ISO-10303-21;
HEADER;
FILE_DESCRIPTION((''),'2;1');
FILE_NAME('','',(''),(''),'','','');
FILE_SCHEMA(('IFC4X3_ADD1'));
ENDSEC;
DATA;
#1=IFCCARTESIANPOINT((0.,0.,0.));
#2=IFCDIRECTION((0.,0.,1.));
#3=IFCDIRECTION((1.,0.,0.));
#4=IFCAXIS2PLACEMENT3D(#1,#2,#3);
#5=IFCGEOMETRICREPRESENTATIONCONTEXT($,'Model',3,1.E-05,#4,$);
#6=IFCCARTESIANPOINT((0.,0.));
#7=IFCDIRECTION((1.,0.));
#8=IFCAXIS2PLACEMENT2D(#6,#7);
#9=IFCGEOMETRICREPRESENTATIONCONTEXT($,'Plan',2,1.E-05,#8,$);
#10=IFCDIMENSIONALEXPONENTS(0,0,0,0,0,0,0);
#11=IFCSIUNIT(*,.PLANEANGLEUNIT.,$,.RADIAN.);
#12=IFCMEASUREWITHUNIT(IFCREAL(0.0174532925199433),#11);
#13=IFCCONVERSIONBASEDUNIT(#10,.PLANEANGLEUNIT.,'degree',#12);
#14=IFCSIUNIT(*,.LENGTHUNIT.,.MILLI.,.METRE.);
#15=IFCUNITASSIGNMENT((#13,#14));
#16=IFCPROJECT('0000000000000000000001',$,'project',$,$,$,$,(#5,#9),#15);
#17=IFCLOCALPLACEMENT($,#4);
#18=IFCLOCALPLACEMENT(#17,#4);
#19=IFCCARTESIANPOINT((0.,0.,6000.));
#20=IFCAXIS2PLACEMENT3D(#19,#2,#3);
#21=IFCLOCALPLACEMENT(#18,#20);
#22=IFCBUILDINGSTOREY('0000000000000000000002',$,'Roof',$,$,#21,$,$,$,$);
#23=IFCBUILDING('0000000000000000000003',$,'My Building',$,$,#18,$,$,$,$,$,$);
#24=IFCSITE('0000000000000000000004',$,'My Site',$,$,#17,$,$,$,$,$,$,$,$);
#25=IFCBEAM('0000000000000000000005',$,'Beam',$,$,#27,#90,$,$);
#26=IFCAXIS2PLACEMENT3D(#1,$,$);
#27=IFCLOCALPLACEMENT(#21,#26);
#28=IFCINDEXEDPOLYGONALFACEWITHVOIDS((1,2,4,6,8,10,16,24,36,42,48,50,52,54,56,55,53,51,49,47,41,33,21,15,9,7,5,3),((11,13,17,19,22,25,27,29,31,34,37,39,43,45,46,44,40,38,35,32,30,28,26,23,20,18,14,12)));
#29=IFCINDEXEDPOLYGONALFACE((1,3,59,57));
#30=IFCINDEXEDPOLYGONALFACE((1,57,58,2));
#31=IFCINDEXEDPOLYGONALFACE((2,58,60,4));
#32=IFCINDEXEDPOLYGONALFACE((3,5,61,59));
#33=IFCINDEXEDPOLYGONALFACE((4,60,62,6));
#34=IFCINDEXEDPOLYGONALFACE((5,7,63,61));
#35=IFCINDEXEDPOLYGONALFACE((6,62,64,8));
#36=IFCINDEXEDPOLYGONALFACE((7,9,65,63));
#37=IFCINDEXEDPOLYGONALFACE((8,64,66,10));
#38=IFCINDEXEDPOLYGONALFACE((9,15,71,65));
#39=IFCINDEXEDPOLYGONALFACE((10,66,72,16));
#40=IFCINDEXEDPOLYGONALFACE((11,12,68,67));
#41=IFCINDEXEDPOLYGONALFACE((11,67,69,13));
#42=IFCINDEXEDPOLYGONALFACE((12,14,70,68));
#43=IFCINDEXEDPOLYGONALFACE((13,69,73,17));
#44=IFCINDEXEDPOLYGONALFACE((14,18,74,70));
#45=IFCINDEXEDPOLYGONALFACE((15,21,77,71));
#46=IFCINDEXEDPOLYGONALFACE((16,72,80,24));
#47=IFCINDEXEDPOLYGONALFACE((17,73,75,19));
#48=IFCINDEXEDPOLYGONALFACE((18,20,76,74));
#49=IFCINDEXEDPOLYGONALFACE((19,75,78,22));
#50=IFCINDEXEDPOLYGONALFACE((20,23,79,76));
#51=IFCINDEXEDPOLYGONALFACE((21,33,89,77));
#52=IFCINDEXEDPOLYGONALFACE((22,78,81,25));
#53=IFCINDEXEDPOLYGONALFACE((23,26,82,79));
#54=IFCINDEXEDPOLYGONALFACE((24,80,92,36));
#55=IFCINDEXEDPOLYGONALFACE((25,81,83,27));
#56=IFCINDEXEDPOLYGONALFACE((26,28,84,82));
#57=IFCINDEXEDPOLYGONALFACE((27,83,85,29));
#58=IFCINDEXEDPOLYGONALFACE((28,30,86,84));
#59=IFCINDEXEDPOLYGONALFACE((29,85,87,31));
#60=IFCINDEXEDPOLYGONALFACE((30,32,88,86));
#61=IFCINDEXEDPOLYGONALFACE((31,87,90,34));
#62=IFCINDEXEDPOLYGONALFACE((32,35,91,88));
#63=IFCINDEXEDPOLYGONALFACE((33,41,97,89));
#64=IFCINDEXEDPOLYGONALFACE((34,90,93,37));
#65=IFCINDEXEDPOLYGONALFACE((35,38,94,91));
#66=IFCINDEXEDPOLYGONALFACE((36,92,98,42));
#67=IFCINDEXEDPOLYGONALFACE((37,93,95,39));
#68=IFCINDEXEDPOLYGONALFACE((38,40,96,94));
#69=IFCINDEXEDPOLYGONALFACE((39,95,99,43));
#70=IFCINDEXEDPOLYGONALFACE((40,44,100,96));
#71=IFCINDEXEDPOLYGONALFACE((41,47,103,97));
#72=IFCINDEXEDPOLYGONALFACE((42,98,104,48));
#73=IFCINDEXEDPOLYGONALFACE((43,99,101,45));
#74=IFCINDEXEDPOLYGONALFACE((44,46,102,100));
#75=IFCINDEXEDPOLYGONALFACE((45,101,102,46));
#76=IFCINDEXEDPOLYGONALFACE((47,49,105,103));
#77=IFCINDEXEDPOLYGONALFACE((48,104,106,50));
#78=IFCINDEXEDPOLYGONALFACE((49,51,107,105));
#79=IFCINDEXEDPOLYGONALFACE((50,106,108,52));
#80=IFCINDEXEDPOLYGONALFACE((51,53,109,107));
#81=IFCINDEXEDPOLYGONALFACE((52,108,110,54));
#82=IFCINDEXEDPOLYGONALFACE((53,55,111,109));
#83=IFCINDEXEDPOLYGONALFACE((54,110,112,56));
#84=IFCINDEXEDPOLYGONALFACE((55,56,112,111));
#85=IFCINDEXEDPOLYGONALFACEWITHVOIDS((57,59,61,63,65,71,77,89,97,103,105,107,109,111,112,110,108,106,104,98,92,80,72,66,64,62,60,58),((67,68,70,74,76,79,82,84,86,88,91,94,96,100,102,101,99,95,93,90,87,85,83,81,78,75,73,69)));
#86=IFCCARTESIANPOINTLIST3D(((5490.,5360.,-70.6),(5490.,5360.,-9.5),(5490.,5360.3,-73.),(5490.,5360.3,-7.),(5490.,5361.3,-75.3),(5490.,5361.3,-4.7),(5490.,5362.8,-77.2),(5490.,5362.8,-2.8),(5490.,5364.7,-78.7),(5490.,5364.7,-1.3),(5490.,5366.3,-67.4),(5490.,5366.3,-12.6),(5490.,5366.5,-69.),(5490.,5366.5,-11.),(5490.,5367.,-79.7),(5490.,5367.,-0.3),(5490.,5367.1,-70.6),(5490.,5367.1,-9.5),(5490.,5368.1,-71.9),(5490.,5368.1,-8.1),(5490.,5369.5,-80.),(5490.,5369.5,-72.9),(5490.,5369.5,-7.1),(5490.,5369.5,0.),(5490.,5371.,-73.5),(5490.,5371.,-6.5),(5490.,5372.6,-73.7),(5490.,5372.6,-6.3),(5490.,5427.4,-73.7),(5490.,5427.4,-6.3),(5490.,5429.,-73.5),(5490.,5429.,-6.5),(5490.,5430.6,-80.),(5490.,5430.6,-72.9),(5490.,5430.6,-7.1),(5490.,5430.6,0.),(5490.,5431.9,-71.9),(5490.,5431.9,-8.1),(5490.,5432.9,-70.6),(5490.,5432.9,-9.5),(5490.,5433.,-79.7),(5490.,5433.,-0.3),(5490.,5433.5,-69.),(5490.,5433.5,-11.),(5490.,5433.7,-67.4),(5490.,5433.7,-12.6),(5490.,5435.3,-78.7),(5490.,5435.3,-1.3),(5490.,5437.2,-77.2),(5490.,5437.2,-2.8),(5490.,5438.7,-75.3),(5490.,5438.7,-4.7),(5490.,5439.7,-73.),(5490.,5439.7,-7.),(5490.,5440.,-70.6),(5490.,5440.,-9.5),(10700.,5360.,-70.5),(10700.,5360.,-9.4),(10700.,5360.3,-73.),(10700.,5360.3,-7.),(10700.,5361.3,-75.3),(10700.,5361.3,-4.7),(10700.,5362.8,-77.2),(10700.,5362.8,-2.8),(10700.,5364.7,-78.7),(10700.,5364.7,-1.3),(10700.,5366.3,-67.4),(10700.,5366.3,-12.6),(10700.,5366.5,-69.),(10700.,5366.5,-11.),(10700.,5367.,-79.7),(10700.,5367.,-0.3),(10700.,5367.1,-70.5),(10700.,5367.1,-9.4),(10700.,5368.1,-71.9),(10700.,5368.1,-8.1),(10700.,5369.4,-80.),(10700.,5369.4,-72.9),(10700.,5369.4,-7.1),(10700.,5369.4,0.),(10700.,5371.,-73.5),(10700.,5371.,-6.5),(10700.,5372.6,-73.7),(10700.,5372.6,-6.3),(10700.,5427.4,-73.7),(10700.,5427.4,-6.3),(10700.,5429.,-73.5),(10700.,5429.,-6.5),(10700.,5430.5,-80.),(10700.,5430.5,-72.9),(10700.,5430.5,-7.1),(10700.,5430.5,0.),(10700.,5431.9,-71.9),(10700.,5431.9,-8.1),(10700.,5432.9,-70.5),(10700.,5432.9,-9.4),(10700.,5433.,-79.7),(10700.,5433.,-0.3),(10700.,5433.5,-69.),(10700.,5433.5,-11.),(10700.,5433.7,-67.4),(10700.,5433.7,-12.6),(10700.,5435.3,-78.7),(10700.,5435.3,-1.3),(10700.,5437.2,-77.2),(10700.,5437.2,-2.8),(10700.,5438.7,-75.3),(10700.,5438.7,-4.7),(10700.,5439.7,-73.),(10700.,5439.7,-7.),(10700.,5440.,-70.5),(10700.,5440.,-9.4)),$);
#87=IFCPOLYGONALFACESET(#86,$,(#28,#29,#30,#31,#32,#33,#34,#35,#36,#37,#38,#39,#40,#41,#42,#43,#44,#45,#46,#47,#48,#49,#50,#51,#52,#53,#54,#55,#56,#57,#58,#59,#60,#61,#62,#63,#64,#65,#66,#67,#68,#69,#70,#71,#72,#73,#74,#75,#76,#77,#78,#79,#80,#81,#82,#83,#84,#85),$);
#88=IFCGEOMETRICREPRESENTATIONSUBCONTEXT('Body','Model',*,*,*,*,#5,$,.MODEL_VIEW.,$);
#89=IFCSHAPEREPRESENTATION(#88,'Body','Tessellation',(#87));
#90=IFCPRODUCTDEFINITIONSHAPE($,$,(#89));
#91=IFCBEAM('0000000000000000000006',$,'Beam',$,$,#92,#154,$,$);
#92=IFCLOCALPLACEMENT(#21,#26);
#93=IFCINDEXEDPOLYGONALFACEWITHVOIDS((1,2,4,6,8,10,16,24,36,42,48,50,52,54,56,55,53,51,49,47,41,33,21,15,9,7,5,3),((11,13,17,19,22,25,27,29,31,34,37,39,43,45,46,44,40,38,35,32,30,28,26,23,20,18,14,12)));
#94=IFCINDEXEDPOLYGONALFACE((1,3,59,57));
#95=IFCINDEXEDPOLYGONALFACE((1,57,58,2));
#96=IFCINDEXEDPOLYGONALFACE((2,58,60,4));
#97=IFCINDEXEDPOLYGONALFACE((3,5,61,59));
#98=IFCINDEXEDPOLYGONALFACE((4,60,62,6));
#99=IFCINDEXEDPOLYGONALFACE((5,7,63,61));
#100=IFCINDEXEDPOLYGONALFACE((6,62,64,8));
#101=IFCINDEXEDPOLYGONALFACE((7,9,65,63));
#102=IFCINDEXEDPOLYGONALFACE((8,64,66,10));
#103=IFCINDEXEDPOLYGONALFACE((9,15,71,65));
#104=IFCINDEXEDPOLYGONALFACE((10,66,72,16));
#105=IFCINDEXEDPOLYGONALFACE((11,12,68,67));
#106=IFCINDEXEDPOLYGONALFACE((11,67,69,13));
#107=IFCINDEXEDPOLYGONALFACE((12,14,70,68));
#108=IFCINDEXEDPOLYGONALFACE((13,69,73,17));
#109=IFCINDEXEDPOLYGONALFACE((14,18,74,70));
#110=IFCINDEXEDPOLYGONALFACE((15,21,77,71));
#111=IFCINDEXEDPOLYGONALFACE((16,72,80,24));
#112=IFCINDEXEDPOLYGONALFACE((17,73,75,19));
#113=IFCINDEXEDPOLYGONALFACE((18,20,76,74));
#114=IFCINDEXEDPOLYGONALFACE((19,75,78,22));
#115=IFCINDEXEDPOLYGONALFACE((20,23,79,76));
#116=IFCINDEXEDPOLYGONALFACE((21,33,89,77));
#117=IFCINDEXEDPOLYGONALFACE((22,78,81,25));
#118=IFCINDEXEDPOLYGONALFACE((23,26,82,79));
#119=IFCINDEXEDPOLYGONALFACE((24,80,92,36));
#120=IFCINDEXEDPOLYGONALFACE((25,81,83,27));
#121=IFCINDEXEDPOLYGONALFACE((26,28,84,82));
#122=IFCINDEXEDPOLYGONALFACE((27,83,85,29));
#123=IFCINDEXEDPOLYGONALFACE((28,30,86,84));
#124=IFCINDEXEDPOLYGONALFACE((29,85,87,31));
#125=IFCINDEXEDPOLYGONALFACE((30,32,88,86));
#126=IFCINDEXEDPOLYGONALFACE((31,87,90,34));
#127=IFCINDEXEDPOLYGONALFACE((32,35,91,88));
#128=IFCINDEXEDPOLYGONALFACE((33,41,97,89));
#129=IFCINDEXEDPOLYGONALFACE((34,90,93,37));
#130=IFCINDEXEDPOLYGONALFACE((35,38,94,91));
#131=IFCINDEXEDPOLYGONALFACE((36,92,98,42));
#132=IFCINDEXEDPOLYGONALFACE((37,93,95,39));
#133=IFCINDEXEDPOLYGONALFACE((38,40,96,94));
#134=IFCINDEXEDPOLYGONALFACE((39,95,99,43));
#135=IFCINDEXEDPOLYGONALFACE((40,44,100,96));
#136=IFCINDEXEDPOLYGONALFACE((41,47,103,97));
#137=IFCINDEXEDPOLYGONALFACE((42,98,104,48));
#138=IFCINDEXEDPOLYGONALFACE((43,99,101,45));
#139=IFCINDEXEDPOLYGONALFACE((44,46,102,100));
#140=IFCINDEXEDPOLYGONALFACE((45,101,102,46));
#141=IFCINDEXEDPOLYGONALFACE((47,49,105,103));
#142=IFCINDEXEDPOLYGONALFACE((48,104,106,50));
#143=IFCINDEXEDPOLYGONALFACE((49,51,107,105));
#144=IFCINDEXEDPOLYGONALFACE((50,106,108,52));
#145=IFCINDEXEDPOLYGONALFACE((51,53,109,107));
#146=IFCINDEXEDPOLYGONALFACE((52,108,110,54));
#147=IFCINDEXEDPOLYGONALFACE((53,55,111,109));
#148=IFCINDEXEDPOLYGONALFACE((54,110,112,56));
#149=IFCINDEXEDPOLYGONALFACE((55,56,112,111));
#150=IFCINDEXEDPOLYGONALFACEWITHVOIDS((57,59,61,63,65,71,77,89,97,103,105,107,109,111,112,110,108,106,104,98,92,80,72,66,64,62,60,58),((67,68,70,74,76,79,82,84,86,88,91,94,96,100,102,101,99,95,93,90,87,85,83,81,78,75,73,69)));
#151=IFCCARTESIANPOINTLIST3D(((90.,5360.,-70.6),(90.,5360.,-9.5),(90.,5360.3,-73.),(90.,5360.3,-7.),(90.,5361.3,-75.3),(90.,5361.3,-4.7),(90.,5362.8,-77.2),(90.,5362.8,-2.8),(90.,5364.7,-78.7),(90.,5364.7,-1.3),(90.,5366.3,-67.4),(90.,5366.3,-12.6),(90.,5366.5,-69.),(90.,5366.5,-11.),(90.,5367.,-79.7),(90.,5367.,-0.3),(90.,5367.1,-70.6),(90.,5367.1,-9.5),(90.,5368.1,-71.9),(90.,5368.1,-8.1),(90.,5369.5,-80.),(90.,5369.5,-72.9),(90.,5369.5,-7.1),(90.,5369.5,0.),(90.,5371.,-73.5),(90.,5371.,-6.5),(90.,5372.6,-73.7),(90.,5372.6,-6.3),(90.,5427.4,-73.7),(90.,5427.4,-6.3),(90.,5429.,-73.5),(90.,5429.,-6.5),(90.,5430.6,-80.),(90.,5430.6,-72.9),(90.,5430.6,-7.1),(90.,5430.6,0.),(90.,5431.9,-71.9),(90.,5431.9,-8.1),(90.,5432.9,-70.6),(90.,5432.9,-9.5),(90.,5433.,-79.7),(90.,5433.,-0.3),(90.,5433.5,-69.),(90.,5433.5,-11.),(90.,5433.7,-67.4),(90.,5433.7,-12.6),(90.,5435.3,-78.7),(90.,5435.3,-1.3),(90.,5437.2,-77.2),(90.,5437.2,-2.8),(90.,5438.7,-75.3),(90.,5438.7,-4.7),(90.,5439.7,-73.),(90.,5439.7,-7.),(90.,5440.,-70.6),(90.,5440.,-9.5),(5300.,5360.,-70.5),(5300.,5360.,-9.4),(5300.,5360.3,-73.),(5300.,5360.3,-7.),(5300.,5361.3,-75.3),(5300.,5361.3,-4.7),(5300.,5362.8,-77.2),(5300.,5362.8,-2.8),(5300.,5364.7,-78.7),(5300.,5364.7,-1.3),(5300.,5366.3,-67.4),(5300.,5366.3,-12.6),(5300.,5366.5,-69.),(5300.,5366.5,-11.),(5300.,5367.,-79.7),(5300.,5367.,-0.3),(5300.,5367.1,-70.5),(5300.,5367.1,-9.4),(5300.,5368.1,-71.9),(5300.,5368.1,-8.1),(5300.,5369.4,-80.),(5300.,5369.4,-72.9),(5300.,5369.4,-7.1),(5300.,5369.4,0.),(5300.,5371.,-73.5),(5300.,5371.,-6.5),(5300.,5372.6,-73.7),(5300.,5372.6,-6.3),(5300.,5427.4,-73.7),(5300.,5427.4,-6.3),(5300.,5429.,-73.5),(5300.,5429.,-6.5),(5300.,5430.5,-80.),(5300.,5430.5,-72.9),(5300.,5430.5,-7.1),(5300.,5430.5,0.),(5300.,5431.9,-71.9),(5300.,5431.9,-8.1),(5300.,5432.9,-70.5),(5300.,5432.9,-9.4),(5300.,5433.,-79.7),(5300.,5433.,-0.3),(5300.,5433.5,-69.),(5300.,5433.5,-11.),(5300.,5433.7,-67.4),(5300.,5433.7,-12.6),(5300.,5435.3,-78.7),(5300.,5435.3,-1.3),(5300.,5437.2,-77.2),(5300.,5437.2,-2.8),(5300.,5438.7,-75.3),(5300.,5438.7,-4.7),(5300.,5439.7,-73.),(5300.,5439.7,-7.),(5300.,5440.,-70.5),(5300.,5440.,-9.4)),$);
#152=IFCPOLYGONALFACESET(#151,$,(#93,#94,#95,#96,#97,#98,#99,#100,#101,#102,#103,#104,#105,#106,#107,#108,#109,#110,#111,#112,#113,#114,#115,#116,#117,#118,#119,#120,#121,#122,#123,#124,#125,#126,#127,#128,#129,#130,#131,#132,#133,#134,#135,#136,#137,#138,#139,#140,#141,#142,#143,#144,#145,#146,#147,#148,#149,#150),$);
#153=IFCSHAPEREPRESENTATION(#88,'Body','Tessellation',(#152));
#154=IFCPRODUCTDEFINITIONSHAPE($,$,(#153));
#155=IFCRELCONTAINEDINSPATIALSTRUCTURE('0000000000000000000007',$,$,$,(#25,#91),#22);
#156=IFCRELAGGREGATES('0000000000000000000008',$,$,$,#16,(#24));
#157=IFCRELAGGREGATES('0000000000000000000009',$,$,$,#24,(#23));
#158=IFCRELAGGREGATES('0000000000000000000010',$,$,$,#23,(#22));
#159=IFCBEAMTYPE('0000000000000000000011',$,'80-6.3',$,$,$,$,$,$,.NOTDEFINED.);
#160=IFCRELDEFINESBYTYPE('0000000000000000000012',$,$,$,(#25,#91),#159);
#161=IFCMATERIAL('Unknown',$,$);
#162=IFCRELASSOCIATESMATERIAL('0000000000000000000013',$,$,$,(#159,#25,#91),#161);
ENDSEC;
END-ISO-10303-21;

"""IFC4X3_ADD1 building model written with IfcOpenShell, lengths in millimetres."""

from ifc_helpers import new_model, entity, si_unit, converted_unit, frame, origin_with_axes, origin_2d_with_axis, place, context, subcontext, project, spatial, hollow_rectangle, extrude, material, material_profile, profile_set, profile_usage, type_object, element, save


model = new_model("IFC4X3_ADD1")

# Units and contexts
model_context = context("Model", 3, precision=1e-05, world=origin_with_axes())
plan_context = context("Plan", 2, precision=1e-05, world=origin_2d_with_axis())
body_context = subcontext(model_context, "Body", "Model", "MODEL_VIEW")
ifc_project = project(units=[converted_unit("PLANEANGLEUNIT", "degree", entity("IfcReal", 0.0174532925199433), si_unit("PLANEANGLEUNIT", "RADIAN"), dimensions=[0, 0, 0, 0, 0, 0, 0]), si_unit("LENGTHUNIT", "METRE", prefix="MILLI")], contexts=[model_context, plan_context])

# Site, building, storey
site_placement = place(None, origin_with_axes())
site = spatial("IfcSite", under=ifc_project, at=site_placement, Name="My Site")
building_placement = place(site_placement, origin_with_axes())
building = spatial("IfcBuilding", under=site, at=building_placement, Name="My Building")
storey_placement = place(building_placement, frame((0.0, 0.0, 6000.0), z_axis=(0.0, 0.0, 1.0), x_axis=(1.0, 0.0, 0.0)))
storey = spatial("IfcBuildingStorey", under=building, at=storey_placement, Name="Roof")

# Beams
ifc_material = material(Name="Unknown")
ifc_material_profile_1 = material_profile(ifc_material, hollow_rectangle(XDim=80.0, YDim=80.0, WallThickness=6.3, InnerFilletRadius=6.3, OuterFilletRadius=9.4))
ifc_profile_set_1 = profile_set([ifc_material_profile_1])
beam_type_1 = type_object("IfcBeamType", Name="80-6.3", PredefinedType="NOTDEFINED", material=ifc_profile_set_1)
ifc_profile_usage_1 = profile_usage(ifc_profile_set_1, cardinal=8)
beam_1_placement = place(storey_placement, frame((5490.0, 5400.0, 0.0), z_axis=(1.0, 0.0, 0.0), x_axis=(0.0, 1.0, 0.0)))
element("IfcBeam", 1, at=beam_1_placement, inside=storey, type_object=beam_type_1, material=ifc_profile_usage_1, Name="Beam", context=body_context, shape_type="SweptSolid", body=[
    extrude(hollow_rectangle(XDim=80.0, YDim=80.0, WallThickness=6.3, InnerFilletRadius=6.3, OuterFilletRadius=9.4), frame((0.0, -40.0, 0.0), z_axis=(0.0, 0.0, 1.0), x_axis=(1.0, 0.0, 0.0)), (0.0, 0.0, 1.0), 5210.0),
])
ifc_profile_usage_2 = profile_usage(ifc_profile_set_1, cardinal=8)
beam_2_placement = place(storey_placement, frame((90.0, 5400.0, 0.0), z_axis=(1.0, 0.0, 0.0), x_axis=(0.0, 1.0, 0.0)))
element("IfcBeam", 2, at=beam_2_placement, inside=storey, type_object=beam_type_1, material=ifc_profile_usage_2, Name="Beam", context=body_context, shape_type="SweptSolid", body=[
    extrude(hollow_rectangle(XDim=80.0, YDim=80.0, WallThickness=6.3, InnerFilletRadius=6.3, OuterFilletRadius=9.4), frame((0.0, -40.0, 0.0), z_axis=(0.0, 0.0, 1.0), x_axis=(1.0, 0.0, 0.0)), (0.0, 0.0, 1.0), 5210.0),
])

save(model, "model.ifc")
